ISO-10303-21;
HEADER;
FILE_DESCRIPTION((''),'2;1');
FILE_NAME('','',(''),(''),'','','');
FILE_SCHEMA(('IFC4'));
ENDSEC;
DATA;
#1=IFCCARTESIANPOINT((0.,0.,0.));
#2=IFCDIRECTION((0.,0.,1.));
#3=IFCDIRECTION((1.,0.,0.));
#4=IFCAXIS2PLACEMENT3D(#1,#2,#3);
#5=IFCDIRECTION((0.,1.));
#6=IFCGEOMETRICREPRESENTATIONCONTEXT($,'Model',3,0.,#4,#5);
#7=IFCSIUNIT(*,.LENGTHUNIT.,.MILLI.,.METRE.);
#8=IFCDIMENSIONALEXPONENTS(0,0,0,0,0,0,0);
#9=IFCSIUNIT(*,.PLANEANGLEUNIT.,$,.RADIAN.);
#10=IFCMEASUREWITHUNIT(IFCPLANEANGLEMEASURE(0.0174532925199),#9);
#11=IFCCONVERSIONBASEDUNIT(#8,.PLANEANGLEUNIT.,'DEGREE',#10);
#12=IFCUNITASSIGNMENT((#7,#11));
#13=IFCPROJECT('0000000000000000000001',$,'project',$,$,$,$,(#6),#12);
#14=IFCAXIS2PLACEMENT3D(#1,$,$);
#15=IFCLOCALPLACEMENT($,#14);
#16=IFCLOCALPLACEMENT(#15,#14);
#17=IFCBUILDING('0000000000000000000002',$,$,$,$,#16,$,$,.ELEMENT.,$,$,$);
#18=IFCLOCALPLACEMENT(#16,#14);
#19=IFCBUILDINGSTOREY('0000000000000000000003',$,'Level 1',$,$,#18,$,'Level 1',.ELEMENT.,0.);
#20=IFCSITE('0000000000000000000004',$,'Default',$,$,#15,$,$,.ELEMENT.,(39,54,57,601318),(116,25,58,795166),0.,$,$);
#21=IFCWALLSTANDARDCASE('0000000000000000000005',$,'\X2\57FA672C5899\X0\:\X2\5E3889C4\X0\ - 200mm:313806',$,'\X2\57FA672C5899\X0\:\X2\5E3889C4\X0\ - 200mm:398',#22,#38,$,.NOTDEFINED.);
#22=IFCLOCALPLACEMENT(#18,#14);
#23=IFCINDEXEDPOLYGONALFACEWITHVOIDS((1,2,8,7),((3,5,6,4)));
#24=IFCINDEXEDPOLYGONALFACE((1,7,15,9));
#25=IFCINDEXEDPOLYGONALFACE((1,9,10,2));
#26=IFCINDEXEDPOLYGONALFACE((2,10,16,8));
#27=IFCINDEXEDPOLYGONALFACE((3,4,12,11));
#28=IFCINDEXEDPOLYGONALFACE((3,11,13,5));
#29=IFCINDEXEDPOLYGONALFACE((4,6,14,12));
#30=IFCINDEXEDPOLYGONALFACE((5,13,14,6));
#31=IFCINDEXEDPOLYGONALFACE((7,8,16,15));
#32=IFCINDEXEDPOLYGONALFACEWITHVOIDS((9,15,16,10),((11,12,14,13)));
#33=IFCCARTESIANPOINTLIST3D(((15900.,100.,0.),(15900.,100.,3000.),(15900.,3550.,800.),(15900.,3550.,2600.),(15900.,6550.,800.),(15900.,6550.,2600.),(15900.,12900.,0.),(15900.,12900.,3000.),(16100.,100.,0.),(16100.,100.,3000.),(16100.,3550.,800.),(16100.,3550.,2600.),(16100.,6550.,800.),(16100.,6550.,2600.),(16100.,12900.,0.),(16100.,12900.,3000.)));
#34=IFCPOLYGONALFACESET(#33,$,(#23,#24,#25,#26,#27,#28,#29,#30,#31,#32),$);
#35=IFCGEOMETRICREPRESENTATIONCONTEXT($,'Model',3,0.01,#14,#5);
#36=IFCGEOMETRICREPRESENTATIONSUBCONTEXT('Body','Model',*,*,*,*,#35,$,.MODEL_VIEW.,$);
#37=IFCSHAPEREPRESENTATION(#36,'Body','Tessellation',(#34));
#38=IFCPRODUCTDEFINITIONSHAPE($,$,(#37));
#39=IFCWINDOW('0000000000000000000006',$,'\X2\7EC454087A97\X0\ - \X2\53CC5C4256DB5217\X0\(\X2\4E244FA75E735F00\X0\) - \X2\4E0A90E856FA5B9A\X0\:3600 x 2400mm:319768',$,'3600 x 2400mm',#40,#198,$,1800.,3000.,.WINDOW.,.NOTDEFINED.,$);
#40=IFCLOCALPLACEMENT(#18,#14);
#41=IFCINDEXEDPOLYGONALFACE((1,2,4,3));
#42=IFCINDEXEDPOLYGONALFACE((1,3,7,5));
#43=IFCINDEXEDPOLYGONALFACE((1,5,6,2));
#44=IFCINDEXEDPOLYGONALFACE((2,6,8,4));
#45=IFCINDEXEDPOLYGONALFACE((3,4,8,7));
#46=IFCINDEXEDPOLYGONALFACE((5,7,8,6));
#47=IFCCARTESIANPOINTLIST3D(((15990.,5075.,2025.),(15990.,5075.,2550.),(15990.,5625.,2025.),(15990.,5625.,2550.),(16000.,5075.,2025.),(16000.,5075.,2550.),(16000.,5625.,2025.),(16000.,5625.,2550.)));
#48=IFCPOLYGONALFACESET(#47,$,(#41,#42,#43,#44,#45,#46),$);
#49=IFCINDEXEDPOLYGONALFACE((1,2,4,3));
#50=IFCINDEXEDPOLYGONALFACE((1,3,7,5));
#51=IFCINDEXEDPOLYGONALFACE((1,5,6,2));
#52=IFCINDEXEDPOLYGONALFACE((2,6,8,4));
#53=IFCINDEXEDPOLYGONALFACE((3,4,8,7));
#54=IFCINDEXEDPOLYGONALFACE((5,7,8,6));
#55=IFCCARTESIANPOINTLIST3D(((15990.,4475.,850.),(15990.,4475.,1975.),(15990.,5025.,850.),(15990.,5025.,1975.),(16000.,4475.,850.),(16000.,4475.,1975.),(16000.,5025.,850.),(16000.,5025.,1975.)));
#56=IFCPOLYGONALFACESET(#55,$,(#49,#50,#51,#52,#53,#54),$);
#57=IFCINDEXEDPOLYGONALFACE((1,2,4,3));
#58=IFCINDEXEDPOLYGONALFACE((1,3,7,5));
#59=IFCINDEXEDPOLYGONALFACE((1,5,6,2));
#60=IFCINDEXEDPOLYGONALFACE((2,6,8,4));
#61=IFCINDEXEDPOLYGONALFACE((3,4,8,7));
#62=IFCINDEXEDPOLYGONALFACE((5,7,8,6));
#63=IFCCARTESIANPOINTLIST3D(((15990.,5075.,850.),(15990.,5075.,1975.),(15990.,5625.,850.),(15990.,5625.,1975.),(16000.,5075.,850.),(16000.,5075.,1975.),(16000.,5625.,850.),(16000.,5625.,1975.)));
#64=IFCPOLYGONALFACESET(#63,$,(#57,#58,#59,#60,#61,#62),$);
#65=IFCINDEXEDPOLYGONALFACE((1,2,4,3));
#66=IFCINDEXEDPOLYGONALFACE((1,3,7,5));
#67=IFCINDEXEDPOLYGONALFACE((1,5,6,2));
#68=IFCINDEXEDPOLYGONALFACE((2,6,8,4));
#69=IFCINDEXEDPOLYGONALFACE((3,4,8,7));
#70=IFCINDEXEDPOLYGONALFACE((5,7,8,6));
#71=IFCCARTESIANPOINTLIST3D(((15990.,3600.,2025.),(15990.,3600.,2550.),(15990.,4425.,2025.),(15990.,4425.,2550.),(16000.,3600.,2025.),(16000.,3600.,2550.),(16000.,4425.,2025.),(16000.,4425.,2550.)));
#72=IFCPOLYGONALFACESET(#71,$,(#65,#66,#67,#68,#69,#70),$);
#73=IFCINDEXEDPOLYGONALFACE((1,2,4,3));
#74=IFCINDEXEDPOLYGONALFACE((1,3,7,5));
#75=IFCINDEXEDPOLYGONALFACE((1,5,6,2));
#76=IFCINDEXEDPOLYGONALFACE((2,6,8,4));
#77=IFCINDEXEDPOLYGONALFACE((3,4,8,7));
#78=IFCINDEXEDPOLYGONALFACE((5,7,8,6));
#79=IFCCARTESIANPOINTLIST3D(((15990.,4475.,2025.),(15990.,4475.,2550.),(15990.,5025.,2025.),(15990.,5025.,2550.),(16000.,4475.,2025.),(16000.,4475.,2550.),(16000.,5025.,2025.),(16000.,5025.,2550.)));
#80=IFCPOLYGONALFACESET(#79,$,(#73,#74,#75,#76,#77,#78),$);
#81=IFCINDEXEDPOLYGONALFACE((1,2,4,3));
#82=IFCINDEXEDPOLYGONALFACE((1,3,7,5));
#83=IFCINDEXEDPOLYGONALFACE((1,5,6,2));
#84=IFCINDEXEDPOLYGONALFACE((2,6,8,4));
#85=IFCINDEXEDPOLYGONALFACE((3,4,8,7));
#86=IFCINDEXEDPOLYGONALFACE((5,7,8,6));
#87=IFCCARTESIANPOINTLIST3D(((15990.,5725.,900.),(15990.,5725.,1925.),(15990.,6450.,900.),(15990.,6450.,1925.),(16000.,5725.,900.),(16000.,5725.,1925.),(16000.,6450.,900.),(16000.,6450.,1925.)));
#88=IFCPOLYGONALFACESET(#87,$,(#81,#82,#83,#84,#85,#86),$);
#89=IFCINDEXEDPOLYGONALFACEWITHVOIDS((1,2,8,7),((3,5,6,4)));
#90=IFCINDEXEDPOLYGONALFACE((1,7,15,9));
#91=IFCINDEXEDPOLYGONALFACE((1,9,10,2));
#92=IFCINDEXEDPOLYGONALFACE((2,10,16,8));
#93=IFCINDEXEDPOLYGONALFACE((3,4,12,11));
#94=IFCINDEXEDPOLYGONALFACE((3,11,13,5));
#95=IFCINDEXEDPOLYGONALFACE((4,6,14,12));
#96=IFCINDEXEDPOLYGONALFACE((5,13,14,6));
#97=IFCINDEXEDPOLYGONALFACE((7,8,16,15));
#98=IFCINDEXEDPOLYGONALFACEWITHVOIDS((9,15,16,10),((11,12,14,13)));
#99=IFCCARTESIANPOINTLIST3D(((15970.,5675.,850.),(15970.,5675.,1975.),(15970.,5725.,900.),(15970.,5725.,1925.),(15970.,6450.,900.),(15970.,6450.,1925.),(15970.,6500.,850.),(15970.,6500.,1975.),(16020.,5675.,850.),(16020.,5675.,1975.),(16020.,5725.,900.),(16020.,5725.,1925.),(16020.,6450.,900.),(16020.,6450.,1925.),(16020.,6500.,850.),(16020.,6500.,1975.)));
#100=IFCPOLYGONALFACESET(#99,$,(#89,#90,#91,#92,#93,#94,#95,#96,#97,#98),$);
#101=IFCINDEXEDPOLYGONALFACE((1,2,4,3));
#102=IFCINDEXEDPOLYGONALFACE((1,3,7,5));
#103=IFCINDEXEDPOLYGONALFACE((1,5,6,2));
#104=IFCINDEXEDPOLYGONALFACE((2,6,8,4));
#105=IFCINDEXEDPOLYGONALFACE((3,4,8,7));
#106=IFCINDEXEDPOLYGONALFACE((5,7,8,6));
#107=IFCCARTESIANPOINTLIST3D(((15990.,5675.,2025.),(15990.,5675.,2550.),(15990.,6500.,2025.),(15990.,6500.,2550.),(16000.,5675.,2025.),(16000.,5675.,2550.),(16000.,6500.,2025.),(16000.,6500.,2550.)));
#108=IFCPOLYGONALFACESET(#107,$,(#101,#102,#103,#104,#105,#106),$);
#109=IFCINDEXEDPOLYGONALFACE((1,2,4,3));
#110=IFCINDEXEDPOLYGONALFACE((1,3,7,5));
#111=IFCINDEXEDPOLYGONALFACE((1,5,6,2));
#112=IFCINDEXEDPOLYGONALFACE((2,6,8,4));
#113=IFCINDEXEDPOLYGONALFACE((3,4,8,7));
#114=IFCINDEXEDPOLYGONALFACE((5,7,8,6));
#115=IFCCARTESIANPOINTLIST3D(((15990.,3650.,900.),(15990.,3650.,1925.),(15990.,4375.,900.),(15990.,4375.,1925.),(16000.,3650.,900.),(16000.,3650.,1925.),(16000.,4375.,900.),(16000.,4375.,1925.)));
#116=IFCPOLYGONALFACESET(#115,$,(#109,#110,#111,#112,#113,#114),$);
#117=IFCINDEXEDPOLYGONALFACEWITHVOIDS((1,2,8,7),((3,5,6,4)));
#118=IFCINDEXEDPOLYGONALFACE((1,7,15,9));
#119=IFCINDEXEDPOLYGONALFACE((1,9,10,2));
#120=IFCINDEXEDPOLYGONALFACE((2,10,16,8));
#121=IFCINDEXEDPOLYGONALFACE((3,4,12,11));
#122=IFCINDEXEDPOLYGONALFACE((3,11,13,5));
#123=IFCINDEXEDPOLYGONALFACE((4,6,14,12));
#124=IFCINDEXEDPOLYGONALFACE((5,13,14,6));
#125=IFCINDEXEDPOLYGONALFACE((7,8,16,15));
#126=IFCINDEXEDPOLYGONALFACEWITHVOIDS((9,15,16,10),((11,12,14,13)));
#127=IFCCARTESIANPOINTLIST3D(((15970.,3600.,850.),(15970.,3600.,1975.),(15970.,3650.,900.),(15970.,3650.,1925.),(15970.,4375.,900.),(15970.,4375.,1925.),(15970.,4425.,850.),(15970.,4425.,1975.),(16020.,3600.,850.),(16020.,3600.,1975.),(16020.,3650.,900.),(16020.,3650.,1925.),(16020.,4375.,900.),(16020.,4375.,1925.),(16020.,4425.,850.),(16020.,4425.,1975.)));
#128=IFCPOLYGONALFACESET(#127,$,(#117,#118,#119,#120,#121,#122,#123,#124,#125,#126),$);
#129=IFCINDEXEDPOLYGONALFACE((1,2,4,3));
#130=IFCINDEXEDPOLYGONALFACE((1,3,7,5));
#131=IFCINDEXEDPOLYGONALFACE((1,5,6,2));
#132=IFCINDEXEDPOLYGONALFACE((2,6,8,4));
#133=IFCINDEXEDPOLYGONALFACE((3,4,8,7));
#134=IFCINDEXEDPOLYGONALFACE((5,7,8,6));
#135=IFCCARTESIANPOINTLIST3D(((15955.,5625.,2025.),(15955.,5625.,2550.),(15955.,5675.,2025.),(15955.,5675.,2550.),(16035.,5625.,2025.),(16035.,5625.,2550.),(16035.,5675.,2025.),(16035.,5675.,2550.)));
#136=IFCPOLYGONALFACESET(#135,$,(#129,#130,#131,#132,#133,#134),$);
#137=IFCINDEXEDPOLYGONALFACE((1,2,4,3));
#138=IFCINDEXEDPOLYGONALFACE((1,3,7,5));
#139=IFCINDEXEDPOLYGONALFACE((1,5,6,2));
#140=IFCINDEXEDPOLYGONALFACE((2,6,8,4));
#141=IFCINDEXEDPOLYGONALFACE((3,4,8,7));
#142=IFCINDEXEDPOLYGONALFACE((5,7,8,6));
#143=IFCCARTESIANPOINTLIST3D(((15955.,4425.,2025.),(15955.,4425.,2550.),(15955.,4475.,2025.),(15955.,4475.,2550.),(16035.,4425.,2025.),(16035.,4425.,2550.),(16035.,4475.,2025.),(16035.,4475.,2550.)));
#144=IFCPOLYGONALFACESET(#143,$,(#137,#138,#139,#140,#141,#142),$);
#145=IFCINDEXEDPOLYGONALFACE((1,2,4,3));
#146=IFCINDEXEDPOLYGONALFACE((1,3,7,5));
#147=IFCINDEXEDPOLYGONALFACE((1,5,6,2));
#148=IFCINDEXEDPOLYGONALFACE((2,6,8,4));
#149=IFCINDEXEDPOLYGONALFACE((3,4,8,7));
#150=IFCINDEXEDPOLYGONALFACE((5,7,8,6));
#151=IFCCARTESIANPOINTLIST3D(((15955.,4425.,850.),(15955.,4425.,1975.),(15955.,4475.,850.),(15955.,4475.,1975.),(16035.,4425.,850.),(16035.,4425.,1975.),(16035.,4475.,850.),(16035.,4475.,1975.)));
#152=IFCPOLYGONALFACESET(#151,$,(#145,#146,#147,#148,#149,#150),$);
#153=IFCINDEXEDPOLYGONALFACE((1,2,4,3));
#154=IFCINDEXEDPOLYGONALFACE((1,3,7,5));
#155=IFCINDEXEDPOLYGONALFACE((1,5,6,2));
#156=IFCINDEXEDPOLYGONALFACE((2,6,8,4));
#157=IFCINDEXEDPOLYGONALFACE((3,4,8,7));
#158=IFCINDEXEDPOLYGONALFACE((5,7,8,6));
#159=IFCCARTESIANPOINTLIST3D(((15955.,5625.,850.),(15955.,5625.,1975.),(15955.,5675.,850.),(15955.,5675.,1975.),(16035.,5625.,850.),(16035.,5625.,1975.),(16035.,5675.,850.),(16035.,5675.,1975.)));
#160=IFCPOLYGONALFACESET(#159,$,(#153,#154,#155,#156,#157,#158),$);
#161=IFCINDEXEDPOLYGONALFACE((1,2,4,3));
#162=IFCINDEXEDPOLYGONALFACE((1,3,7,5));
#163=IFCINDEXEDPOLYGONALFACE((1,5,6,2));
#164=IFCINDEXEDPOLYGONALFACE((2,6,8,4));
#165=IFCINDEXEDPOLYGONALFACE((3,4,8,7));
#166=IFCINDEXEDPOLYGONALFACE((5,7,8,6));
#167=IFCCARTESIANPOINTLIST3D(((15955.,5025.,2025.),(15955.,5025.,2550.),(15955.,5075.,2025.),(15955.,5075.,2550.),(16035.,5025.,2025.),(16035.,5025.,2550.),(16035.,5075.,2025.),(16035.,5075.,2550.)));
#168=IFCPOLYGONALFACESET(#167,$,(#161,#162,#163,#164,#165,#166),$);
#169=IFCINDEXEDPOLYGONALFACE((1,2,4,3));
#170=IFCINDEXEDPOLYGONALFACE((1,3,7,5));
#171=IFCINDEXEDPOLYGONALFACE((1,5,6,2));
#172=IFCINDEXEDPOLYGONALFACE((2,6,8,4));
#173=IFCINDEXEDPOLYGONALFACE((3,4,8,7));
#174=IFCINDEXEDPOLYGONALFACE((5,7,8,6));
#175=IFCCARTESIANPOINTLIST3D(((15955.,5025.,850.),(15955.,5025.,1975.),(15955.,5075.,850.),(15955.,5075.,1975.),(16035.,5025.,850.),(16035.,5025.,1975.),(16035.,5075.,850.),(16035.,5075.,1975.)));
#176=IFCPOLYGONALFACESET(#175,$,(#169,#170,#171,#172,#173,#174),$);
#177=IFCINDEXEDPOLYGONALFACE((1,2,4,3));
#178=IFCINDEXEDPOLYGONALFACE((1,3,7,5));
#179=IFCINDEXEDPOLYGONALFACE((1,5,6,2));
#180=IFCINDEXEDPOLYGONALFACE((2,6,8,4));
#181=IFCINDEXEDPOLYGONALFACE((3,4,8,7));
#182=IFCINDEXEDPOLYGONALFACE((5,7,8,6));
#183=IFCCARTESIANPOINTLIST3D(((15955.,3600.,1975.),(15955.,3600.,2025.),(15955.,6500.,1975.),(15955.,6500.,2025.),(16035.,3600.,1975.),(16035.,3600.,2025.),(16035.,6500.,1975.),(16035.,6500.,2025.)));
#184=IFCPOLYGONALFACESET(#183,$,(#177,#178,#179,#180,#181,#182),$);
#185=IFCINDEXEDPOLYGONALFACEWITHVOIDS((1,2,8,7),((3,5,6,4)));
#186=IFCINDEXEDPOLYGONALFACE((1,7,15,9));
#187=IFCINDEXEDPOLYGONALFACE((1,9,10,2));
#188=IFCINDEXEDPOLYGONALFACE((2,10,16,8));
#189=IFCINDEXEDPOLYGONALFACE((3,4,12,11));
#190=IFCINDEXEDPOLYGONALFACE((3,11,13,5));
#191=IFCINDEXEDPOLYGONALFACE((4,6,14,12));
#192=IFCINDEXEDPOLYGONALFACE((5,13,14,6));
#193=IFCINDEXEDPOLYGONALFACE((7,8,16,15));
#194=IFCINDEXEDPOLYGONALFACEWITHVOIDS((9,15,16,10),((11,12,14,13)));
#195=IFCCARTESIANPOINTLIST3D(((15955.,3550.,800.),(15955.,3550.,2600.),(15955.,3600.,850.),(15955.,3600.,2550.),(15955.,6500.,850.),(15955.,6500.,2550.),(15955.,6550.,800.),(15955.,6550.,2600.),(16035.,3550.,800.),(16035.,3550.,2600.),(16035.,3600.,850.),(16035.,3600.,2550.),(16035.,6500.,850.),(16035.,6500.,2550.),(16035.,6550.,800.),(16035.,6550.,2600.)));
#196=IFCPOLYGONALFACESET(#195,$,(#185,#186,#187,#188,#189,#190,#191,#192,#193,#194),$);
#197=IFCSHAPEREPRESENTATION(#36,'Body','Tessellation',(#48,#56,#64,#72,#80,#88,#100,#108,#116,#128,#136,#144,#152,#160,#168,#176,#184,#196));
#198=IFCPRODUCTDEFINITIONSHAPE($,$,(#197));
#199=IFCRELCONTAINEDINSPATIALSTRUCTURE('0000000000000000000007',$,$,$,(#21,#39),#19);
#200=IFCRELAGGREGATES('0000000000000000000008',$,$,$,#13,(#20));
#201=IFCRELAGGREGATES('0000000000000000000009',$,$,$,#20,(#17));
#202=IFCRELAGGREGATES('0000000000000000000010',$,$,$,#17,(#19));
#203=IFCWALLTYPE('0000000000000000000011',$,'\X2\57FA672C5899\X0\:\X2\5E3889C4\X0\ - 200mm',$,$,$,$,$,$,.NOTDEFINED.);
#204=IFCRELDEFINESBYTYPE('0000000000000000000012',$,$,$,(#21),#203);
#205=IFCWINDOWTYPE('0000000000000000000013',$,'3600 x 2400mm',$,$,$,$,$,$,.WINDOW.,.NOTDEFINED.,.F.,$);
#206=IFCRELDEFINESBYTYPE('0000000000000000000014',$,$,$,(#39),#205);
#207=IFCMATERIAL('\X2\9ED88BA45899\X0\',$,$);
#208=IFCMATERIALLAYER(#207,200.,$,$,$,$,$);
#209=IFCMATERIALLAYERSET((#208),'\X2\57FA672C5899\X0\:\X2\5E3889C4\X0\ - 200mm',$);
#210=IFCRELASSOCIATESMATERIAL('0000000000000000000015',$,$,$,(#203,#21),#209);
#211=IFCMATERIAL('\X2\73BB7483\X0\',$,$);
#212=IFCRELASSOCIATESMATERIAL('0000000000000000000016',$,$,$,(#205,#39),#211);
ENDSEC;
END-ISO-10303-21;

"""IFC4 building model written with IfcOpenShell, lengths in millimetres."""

from ifc_helpers import new_model, entity, si_unit, converted_unit, direction, frame, frame_2d, origin, origin_with_axes, origin_2d_with_axis, place, context, subcontext, project, spatial, polyline, rectangle, outline, extrude, source, transform, mapped, material, layer, layer_set, layer_usage, type_object, type_shapes, element, fill, save


model = new_model("IFC4")

# Units and contexts
model_context_1 = context("Model", 3, precision=0.0, world=origin_with_axes(), true_north=direction((0.0, 1.0)))
model_context_2 = context("Model", 3, precision=0.01, world=origin(), true_north=direction((0.0, 1.0)))
body_context = subcontext(model_context_2, "Body", "Model", "MODEL_VIEW")
ifc_project = project(units=[si_unit("LENGTHUNIT", "METRE", prefix="MILLI"), converted_unit("PLANEANGLEUNIT", "DEGREE", entity("IfcPlaneAngleMeasure", 0.0174532925199), si_unit("PLANEANGLEUNIT", "RADIAN"), dimensions=[0, 0, 0, 0, 0, 0, 0])], contexts=[model_context_1])

# Site, building, storey
site_placement = place(None, origin())
site = spatial("IfcSite", under=ifc_project, at=site_placement, Name="Default", CompositionType="ELEMENT", RefLatitude=(39, 54, 57, 601318), RefLongitude=(116, 25, 58, 795166), RefElevation=0.0)
building_placement = place(site_placement, origin())
building = spatial("IfcBuilding", under=site, at=building_placement, CompositionType="ELEMENT")
storey_placement = place(building_placement, origin())
storey = spatial("IfcBuildingStorey", under=building, at=storey_placement, Name="Level 1", LongName="Level 1", CompositionType="ELEMENT", Elevation=0.0)

# Shared definitions
ifc_material_1 = material(Name="默认墙")
ifc_layer = layer(ifc_material_1, 200.0)
ifc_layer_set = layer_set([ifc_layer], Name="基本墙:常规 - 200mm")
wall_type = type_object("IfcWallType", Name="基本墙:常规 - 200mm", PredefinedType="NOTDEFINED", material=ifc_layer_set)
ifc_material_2 = material(Name="玻璃")
window_type_1 = type_object("IfcWindowType", Name="3600 x 2400mm", ParameterTakesPrecedence=False, PartitioningType="NOTDEFINED", PredefinedType="WINDOW", material=ifc_material_2)
shared_shape_1 = source(origin(), body_context, "Body", "SweptSolid", [
    extrude(rectangle(XDim=10.0, YDim=550.0, at=origin_2d_with_axis()), frame((1200.0, 95.0, 1225.0), z_axis=(0.0, 0.0, 1.0), x_axis=(0.0, 1.0, 0.0)), (0.0, 0.0, 1.0), 525.0),
    extrude(rectangle(XDim=10.0, YDim=550.0, at=origin_2d_with_axis()), frame((1800.0, 95.0, 50.0), z_axis=(0.0, 0.0, 1.0), x_axis=(0.0, 1.0, 0.0)), (0.0, 0.0, 1.0), 1125.0),
    extrude(rectangle(XDim=10.0, YDim=550.0, at=origin_2d_with_axis()), frame((1200.0, 95.0, 50.0), z_axis=(0.0, 0.0, 1.0), x_axis=(0.0, 1.0, 0.0)), (0.0, 0.0, 1.0), 1125.0),
    extrude(rectangle(XDim=10.0, YDim=825.0, at=origin_2d_with_axis()), frame((2537.5, 95.0, 1225.0), z_axis=(0.0, 0.0, 1.0), x_axis=(0.0, 1.0, 0.0)), (0.0, 0.0, 1.0), 525.0),
    extrude(rectangle(XDim=10.0, YDim=550.0, at=origin_2d_with_axis()), frame((1800.0, 95.0, 1225.0), z_axis=(0.0, 0.0, 1.0), x_axis=(0.0, 1.0, 0.0)), (0.0, 0.0, 1.0), 525.0),
    extrude(rectangle(XDim=10.0, YDim=725.0, at=origin_2d_with_axis()), frame((462.5, 95.0, 100.0), z_axis=(0.0, 0.0, 1.0), x_axis=(0.0, 1.0, 0.0)), (0.0, 0.0, 1.0), 1025.0),
    extrude(outline(polyline([(-562.5, -412.5), (562.5, -412.5), (562.5, 412.5), (-562.5, 412.5), (-562.5, -412.5)]), holes=[polyline([(512.5, -362.5), (-512.5, -362.5), (-512.5, 362.5), (512.5, 362.5), (512.5, -362.5)])]), frame((462.5, 70.0, 612.5), z_axis=(0.0, 1.0, 0.0), x_axis=(0.0, 0.0, -1.0)), (0.0, 0.0, 1.0), 50.0),
    extrude(rectangle(XDim=10.0, YDim=825.0, at=origin_2d_with_axis()), frame((462.5, 95.0, 1225.0), z_axis=(0.0, 0.0, 1.0), x_axis=(0.0, 1.0, 0.0)), (0.0, 0.0, 1.0), 525.0),
    extrude(rectangle(XDim=10.0, YDim=725.0, at=origin_2d_with_axis()), frame((2537.5, 95.0, 100.0), z_axis=(0.0, 0.0, 1.0), x_axis=(0.0, 1.0, 0.0)), (0.0, 0.0, 1.0), 1025.0),
    extrude(outline(polyline([(-562.5, -412.5), (562.5, -412.5), (562.5, 412.5), (-562.5, 412.5), (-562.5, -412.5)]), holes=[polyline([(512.5, -362.5), (-512.5, -362.5), (-512.5, 362.5), (512.5, 362.5), (512.5, -362.5)])]), frame((2537.5, 70.0, 612.5), z_axis=(0.0, 1.0, 0.0), x_axis=(0.0, 0.0, -1.0)), (0.0, 0.0, 1.0), 50.0),
    extrude(rectangle(XDim=80.0, YDim=50.0, at=origin_2d_with_axis()), frame((900.0, 95.0, 1225.0), z_axis=(0.0, 0.0, 1.0), x_axis=(0.0, -1.0, 0.0)), (0.0, 0.0, 1.0), 525.0),
    extrude(rectangle(XDim=80.0, YDim=50.0, at=origin_2d_with_axis()), frame((2100.0, 95.0, 1225.0), z_axis=(0.0, 0.0, 1.0), x_axis=(0.0, -1.0, 0.0)), (0.0, 0.0, 1.0), 525.0),
    extrude(rectangle(XDim=80.0, YDim=50.0, at=origin_2d_with_axis()), frame((2100.0, 95.0, 50.0), z_axis=(0.0, 0.0, 1.0), x_axis=(0.0, -1.0, 0.0)), (0.0, 0.0, 1.0), 1125.0),
    extrude(rectangle(XDim=80.0, YDim=50.0, at=origin_2d_with_axis()), frame((900.0, 95.0, 50.0), z_axis=(0.0, 0.0, 1.0), x_axis=(0.0, -1.0, 0.0)), (0.0, 0.0, 1.0), 1125.0),
    extrude(rectangle(XDim=80.0, YDim=50.0, at=origin_2d_with_axis()), frame((1500.0, 95.0, 1225.0), z_axis=(0.0, 0.0, 1.0), x_axis=(0.0, -1.0, 0.0)), (0.0, 0.0, 1.0), 525.0),
    extrude(rectangle(XDim=80.0, YDim=50.0, at=origin_2d_with_axis()), frame((1500.0, 95.0, 50.0), z_axis=(0.0, 0.0, 1.0), x_axis=(0.0, -1.0, 0.0)), (0.0, 0.0, 1.0), 1125.0),
    extrude(rectangle(XDim=80.0, YDim=2900.0, at=origin_2d_with_axis()), frame((1500.0, 95.0, 1175.0), z_axis=(0.0, 0.0, 1.0), x_axis=(0.0, -1.0, 0.0)), (0.0, 0.0, 1.0), 50.0),
    extrude(outline(polyline([(-1500.0, -900.0), (1500.0, -900.0), (1500.0, 900.0), (-1500.0, 900.0), (-1500.0, -900.0)]), holes=[polyline([(1450.0, -850.0), (-1450.0, -850.0), (-1450.0, 850.0), (1450.0, 850.0), (1450.0, -850.0)])]), frame((1500.0, 55.0, 900.0), z_axis=(0.0, 1.0, 0.0), x_axis=(1.0, 0.0, 0.0)), (0.0, 0.0, 1.0), 80.0),
])
type_shapes(window_type_1, [shared_shape_1])

# Wall, opening, window
ifc_layer_usage_1 = layer_usage(ifc_layer_set, "AXIS2", "NEGATIVE", 100.0)
wall_1_placement = place(storey_placement, frame((16000.0, 12900.0, 0.0), z_axis=(0.0, 0.0, 1.0), x_axis=(0.0, -1.0, 0.0)))
wall_1 = element("IfcWallStandardCase", 1, at=wall_1_placement, inside=storey, type_object=wall_type, material=ifc_layer_usage_1, Name="基本墙:常规 - 200mm:313806", ObjectType="基本墙:常规 - 200mm:398", PredefinedType="NOTDEFINED", context=body_context, shape_type="SweptSolid", body=[
    extrude(rectangle(XDim=12800.0, YDim=200.0, at=frame_2d((6400.0, 0.0), x_axis=(-1.0, 0.0))), origin(), (0.0, 0.0, 1.0), 3000.0),
])
opening_1_placement = place(wall_1_placement, frame((6350.0, -100.0, 800.0)))
opening_1 = element("IfcOpeningElement", 2, at=opening_1_placement, cuts=wall_1, ObjectType="Opening", PredefinedType="OPENING", context=body_context, shape_type="SweptSolid", body=[
    extrude(rectangle(XDim=1800.0, YDim=3000.0, at=frame_2d((900.0, 1500.0), x_axis=(1.0, 0.0))), frame((0.0, 0.0, 0.0), z_axis=(0.0, 1.0, 0.0), x_axis=(0.0, 0.0, 1.0)), (0.0, 0.0, 1.0), 200.0),
])
window_1_placement = place(opening_1_placement, origin())
window_1 = element("IfcWindow", 3, at=window_1_placement, inside=storey, type_object=window_type_1, material=ifc_material_2, Name="组合窗 - 双层四列(两侧平开) - 上部固定:3600 x 2400mm:319768", ObjectType="3600 x 2400mm", OverallHeight=1800.0, OverallWidth=3000.0, PartitioningType="NOTDEFINED", PredefinedType="WINDOW", context=body_context, shape_type="MappedRepresentation", body=[
    mapped(shared_shape_1, transform((0.0, 0.0, 0.0), scale=1.0)),
])
fill(opening_1, window_1)

save(model, "model.ifc")
